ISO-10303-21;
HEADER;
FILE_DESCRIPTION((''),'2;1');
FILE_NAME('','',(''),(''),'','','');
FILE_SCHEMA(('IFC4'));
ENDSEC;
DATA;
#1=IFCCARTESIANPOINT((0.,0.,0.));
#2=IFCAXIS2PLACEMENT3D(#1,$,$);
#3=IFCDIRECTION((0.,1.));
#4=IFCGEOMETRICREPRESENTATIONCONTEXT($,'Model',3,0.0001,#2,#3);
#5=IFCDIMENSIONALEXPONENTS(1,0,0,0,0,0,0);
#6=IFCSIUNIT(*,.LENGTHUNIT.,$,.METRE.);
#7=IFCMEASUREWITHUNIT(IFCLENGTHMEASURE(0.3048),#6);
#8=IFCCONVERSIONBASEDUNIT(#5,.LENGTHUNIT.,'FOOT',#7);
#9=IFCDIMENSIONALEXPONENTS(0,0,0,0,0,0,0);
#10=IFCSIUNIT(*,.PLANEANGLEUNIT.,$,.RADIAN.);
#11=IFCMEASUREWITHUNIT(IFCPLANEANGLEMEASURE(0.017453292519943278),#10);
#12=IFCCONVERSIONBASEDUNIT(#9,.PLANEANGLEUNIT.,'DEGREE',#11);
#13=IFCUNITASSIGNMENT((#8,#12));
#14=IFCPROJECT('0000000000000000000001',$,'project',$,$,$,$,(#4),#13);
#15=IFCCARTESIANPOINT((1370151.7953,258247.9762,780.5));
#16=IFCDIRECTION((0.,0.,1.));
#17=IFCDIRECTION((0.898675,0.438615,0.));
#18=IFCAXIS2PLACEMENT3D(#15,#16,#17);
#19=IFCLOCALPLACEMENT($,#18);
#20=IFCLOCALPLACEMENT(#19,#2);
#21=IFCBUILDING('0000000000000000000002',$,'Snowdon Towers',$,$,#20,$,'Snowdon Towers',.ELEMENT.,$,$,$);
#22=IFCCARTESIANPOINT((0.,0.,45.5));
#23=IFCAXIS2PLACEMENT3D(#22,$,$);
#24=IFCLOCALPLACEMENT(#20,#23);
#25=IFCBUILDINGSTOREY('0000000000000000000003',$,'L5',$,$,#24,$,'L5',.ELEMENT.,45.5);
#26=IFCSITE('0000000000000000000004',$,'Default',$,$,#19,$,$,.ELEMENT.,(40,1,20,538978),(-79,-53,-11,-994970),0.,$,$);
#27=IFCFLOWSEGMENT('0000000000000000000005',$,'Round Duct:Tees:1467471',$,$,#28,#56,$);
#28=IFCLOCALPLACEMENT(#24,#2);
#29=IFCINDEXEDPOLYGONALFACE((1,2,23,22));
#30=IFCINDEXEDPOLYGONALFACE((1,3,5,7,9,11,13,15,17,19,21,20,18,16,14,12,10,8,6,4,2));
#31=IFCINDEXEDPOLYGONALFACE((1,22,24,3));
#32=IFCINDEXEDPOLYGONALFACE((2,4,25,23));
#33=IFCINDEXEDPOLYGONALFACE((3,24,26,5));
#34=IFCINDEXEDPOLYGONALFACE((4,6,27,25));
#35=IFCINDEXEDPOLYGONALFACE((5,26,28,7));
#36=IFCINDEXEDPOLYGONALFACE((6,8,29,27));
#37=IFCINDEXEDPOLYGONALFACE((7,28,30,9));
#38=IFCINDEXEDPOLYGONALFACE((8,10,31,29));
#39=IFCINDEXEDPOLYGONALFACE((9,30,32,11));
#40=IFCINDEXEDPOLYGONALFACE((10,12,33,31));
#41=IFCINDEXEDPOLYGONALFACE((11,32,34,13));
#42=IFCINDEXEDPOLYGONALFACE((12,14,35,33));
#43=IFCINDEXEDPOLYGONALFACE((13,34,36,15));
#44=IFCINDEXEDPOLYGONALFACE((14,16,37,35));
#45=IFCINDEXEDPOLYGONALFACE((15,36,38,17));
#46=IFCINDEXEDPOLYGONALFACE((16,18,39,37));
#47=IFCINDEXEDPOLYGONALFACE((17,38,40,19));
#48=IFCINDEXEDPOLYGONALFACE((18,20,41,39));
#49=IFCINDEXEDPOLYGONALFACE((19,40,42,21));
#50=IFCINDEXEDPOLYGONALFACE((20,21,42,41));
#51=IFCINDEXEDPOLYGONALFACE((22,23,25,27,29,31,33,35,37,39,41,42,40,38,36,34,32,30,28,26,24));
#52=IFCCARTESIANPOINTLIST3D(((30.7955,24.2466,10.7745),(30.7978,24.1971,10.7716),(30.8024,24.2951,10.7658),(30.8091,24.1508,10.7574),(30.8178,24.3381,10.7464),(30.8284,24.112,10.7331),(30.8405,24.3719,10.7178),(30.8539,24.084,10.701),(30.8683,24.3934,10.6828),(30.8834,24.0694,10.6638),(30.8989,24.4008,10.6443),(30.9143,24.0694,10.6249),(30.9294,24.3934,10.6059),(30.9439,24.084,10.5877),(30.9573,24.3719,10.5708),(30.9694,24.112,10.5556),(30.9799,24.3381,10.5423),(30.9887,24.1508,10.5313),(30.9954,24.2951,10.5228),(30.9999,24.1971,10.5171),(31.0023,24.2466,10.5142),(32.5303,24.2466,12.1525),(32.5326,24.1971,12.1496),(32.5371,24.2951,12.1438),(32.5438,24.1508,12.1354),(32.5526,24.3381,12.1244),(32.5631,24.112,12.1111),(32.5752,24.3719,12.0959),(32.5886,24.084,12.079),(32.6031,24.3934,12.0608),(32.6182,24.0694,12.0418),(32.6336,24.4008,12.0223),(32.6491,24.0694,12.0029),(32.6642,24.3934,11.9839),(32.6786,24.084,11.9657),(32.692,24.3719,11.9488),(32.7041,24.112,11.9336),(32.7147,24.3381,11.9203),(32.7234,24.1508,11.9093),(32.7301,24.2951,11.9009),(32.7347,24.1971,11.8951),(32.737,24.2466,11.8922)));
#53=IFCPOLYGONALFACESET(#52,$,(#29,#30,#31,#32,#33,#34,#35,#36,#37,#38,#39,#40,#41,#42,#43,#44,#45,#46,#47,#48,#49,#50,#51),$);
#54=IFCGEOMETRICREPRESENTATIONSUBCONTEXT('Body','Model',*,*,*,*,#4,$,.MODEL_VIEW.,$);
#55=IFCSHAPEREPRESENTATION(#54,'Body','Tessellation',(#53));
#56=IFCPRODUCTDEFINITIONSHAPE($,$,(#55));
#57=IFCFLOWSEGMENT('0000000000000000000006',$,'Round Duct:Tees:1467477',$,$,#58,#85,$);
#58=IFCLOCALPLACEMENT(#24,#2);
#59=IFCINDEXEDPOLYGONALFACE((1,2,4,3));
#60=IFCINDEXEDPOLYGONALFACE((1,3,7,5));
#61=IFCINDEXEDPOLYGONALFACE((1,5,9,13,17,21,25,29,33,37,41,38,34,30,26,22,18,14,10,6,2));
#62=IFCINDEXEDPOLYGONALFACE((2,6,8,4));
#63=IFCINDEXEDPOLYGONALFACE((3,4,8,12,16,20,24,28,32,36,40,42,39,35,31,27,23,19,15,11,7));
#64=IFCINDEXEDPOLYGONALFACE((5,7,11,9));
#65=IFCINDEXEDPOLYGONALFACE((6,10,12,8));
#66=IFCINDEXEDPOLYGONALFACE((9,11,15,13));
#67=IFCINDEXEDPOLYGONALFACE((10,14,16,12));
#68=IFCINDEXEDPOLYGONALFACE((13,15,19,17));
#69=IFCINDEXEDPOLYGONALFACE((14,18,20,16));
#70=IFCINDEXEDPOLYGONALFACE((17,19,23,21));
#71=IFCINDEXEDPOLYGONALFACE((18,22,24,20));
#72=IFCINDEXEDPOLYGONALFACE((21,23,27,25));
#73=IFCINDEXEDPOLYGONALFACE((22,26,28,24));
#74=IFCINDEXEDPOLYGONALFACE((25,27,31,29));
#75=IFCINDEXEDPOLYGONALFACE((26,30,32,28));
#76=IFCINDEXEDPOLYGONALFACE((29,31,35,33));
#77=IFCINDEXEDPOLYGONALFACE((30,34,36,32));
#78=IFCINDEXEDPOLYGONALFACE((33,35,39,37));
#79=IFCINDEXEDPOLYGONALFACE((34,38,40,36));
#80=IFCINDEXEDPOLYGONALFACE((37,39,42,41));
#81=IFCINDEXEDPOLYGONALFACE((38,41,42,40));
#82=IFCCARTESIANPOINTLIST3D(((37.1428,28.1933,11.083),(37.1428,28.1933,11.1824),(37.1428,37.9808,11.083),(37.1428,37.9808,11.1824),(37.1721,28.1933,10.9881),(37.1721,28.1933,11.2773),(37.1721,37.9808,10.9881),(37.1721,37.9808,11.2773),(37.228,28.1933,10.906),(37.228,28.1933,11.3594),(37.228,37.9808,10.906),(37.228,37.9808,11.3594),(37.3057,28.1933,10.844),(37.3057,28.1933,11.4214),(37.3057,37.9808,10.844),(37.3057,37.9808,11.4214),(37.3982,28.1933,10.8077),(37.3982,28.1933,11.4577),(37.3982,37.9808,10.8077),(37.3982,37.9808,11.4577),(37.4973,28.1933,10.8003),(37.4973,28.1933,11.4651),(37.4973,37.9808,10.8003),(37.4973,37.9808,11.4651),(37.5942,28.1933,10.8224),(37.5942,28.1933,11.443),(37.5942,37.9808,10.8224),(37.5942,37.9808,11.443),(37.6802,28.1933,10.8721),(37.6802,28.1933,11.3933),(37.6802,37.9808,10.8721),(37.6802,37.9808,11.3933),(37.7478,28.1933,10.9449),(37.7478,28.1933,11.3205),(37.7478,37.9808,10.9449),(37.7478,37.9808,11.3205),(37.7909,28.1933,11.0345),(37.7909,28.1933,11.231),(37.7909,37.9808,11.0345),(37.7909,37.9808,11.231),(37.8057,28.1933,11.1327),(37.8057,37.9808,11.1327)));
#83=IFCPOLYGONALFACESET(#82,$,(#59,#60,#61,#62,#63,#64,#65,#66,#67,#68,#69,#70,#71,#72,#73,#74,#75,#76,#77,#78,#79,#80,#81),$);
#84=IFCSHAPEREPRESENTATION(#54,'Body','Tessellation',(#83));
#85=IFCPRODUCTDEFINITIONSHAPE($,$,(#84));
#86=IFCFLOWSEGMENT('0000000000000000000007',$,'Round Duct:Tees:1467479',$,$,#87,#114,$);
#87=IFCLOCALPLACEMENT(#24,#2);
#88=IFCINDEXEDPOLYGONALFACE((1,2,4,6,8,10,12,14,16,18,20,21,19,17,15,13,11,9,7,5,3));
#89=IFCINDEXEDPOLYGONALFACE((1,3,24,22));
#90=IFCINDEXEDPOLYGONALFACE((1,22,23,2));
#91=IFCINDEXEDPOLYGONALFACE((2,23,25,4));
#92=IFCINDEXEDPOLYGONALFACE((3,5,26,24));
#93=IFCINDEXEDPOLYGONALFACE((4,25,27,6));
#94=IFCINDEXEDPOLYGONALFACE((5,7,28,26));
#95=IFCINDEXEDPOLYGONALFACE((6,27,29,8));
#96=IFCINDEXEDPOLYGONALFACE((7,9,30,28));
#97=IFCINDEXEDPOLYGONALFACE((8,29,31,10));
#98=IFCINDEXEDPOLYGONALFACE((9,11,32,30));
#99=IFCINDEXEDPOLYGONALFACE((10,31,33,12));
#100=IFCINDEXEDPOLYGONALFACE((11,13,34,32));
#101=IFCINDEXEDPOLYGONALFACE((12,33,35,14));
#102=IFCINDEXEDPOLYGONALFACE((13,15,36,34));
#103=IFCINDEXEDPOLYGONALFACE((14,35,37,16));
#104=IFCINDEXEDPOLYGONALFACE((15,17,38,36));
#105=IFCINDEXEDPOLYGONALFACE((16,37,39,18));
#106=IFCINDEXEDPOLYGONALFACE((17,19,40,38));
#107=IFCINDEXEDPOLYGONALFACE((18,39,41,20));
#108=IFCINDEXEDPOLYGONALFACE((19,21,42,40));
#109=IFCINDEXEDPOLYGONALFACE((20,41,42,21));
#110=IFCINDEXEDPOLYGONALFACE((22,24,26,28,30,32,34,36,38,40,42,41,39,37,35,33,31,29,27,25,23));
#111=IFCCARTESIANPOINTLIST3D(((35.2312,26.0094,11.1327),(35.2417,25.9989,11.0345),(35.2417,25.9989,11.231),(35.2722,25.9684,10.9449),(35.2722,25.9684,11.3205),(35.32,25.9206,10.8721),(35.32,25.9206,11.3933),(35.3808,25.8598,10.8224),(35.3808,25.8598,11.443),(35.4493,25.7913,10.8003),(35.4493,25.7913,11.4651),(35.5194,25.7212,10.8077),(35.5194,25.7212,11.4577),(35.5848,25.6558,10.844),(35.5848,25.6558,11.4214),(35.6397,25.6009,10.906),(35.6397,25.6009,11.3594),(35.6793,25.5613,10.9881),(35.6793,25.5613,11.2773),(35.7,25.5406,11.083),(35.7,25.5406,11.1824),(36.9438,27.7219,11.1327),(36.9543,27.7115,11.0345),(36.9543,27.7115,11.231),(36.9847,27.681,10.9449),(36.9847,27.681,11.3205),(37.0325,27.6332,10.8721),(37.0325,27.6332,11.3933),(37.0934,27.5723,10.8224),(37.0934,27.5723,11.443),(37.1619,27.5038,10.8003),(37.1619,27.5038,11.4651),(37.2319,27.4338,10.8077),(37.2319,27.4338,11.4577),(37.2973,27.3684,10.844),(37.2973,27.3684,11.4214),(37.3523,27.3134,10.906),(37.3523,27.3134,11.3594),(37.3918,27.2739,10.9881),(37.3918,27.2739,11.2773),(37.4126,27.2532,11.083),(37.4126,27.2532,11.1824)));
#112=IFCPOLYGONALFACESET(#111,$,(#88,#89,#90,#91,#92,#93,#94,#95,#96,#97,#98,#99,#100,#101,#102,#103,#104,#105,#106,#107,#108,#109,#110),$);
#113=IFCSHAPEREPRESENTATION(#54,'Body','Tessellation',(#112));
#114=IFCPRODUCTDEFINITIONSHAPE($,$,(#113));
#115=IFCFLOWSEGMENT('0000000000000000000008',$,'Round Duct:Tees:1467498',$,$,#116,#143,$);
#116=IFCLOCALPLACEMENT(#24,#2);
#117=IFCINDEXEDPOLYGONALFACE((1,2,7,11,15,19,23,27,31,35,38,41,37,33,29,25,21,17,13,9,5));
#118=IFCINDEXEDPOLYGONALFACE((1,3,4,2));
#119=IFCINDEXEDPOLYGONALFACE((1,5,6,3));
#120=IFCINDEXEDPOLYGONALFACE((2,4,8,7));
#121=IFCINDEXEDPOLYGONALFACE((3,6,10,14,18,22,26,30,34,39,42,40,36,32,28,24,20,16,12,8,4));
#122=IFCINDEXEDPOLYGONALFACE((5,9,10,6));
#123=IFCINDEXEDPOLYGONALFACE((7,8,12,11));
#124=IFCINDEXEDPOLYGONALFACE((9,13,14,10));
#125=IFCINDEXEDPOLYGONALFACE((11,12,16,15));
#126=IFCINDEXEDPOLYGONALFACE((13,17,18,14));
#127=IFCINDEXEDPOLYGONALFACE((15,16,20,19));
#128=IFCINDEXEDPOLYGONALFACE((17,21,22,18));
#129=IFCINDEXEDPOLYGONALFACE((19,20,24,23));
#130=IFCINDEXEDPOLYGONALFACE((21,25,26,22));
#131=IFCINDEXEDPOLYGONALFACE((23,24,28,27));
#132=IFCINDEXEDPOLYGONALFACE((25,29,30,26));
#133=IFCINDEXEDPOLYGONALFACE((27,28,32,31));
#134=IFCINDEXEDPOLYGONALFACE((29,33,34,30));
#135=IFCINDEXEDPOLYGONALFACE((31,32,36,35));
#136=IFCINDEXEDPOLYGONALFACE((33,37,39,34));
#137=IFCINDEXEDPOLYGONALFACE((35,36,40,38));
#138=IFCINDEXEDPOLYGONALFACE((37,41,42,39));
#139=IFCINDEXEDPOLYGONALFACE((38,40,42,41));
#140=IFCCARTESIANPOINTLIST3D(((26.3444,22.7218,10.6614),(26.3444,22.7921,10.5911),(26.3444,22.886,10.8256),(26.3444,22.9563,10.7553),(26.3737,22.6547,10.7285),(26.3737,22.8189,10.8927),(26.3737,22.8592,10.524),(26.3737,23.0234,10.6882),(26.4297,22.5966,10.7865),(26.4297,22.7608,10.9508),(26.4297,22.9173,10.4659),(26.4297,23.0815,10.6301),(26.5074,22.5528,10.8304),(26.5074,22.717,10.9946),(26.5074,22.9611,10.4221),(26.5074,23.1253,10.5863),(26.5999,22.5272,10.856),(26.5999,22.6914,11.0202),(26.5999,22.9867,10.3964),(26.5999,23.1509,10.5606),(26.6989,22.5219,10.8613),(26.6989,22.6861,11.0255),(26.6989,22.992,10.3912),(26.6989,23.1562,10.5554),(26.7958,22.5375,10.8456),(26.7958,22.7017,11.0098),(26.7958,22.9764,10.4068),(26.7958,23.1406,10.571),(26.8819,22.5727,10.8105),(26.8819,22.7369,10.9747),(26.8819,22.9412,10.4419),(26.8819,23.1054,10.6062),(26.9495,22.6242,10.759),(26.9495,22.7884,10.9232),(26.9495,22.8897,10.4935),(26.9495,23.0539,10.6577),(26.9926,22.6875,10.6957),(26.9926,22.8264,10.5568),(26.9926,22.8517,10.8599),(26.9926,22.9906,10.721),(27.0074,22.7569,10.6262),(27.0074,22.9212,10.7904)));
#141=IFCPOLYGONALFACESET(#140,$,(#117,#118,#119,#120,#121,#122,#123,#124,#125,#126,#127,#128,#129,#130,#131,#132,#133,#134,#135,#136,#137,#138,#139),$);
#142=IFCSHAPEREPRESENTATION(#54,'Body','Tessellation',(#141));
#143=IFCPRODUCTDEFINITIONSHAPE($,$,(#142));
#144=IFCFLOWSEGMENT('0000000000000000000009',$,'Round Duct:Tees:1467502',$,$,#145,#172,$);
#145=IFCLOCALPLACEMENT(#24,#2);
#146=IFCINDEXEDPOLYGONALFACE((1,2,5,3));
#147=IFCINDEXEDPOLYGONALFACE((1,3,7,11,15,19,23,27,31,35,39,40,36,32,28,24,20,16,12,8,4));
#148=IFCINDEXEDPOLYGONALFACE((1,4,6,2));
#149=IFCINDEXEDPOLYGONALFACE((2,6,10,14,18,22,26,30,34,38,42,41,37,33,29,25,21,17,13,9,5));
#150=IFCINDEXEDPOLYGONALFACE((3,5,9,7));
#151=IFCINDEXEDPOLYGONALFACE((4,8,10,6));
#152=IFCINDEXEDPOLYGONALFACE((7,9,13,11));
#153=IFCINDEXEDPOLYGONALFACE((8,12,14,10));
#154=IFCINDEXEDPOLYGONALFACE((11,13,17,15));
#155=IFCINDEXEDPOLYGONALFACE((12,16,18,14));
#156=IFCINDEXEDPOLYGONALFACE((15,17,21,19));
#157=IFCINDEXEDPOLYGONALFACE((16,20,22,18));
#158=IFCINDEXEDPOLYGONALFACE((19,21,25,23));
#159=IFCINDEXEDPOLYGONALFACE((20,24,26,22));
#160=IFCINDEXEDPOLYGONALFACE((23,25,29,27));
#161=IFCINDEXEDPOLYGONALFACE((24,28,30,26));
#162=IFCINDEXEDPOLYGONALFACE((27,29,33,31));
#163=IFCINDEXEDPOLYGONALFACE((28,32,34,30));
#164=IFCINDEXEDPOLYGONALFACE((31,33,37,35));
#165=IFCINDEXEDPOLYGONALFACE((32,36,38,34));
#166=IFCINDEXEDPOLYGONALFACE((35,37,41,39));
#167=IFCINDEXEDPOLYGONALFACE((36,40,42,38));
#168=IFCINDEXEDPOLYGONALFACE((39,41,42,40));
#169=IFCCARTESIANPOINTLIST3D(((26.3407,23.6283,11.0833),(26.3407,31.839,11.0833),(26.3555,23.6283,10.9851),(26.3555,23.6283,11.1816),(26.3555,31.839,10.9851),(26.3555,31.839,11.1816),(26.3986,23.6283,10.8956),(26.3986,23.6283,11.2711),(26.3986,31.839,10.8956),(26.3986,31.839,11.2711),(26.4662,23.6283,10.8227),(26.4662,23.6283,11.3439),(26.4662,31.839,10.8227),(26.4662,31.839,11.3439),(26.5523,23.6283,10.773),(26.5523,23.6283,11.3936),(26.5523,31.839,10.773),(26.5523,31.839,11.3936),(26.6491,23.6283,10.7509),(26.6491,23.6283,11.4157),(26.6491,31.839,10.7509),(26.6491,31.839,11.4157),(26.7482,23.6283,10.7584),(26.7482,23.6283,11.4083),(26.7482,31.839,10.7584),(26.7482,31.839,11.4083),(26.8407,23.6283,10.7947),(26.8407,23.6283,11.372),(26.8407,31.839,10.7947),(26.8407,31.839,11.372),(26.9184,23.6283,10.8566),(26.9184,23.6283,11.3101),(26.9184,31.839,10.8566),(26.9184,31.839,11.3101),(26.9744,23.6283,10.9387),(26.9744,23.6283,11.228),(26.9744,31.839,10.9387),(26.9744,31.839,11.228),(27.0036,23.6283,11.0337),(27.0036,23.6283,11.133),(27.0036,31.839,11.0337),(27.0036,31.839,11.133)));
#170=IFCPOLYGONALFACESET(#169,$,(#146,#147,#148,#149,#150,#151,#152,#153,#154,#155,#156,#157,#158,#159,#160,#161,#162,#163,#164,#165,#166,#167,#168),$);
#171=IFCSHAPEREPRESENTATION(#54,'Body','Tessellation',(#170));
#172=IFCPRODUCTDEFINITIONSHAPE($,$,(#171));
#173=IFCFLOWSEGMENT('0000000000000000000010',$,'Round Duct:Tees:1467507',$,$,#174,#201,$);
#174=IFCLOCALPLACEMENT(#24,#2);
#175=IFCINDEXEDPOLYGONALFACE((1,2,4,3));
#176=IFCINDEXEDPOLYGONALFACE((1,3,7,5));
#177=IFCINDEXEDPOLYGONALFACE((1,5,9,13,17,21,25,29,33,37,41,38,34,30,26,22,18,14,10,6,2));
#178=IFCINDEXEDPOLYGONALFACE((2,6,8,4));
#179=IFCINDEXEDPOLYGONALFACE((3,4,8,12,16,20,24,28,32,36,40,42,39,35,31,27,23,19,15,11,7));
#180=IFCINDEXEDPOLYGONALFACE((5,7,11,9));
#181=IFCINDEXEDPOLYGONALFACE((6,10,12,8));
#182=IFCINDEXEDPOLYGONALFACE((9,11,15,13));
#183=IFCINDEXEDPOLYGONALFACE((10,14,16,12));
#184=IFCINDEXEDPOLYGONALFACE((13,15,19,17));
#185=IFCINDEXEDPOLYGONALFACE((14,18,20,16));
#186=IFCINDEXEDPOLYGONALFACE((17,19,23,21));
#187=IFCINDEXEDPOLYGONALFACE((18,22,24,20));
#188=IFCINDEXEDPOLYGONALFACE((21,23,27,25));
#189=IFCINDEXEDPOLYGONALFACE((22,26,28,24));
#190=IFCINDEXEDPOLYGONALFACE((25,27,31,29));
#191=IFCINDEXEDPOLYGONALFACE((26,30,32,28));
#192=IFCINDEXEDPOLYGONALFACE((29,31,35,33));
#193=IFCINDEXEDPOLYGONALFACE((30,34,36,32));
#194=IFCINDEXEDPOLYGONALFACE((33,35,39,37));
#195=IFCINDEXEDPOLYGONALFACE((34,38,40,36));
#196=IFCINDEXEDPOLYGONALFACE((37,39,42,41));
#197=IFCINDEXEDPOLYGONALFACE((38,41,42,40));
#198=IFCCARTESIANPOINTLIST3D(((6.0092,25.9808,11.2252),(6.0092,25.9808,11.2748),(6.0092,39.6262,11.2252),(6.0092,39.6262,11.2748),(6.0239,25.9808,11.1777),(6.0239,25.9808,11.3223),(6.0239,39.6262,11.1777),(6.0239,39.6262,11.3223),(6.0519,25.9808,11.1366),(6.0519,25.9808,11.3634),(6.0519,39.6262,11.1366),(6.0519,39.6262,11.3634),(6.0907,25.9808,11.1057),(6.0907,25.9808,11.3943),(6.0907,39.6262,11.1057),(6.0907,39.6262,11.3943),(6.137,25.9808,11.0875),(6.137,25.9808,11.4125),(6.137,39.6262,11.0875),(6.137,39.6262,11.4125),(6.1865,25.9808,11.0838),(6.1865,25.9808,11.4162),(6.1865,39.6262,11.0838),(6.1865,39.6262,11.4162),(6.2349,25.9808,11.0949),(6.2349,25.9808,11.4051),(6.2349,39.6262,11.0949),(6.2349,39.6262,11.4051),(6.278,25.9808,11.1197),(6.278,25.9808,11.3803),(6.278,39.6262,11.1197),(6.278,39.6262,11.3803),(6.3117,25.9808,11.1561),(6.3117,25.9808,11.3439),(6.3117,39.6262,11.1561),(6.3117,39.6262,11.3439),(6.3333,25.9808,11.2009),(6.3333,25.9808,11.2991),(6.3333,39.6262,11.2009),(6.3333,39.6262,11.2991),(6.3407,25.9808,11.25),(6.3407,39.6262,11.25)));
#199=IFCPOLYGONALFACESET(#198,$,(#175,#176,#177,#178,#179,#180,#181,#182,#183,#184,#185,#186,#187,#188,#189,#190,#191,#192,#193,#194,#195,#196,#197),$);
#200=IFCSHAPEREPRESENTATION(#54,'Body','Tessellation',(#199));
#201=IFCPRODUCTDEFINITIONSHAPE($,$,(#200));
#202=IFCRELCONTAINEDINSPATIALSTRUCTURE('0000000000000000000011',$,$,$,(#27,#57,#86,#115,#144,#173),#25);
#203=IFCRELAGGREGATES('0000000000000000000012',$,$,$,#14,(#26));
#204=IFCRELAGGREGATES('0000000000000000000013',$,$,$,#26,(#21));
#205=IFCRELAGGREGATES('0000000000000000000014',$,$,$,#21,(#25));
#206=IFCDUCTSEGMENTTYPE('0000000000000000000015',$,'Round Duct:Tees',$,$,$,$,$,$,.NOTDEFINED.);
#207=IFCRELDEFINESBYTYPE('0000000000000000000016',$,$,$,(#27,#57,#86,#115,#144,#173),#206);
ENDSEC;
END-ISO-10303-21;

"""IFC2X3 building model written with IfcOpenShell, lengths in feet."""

from ifc_helpers import new_model, entity, si_unit, converted_unit, direction, frame, frame_2d, origin, origin_2d_with_axis, place, context, subcontext, project, spatial, circle, extrude, type_object, element, save


model = new_model("IFC2X3")

# Units and contexts
model_context = context("Model", 3, precision=0.0001, world=origin(), true_north=direction((0.0, 1.0)))
body_context = subcontext(model_context, "Body", "Model", "MODEL_VIEW")
ifc_project = project(units=[converted_unit("LENGTHUNIT", "FOOT", entity("IfcLengthMeasure", 0.3048), si_unit("LENGTHUNIT", "METRE"), dimensions=[1, 0, 0, 0, 0, 0, 0]), converted_unit("PLANEANGLEUNIT", "DEGREE", entity("IfcPlaneAngleMeasure", 0.017453292519943278), si_unit("PLANEANGLEUNIT", "RADIAN"), dimensions=[0, 0, 0, 0, 0, 0, 0])], contexts=[model_context])

# Site, building, storey
site_placement = place(None, frame((1370151.7953, 258247.9762, 780.5), z_axis=(0.0, 0.0, 1.0), x_axis=(0.898675, 0.438615, 0.0)))
site = spatial("IfcSite", under=ifc_project, at=site_placement, Name="Default", CompositionType="ELEMENT", RefLatitude=(40, 1, 20, 538978), RefLongitude=(-79, -53, -11, -994970), RefElevation=0.0)
building_placement = place(site_placement, origin())
building = spatial("IfcBuilding", under=site, at=building_placement, Name="Snowdon Towers", LongName="Snowdon Towers", CompositionType="ELEMENT")
storey_placement = place(building_placement, frame((0.0, 0.0, 45.5)))
storey = spatial("IfcBuildingStorey", under=building, at=storey_placement, Name="L5", LongName="L5", CompositionType="ELEMENT", Elevation=45.5)

# Flow segments
duct_segment_type = type_object("IfcDuctSegmentType", Name="Round Duct:Tees", PredefinedType="NOTDEFINED")
flow_segment_1_placement = place(storey_placement, origin())
element("IfcFlowSegment", 1, at=flow_segment_1_placement, inside=storey, type_object=duct_segment_type, Name="Round Duct:Tees:1467471", context=body_context, shape_type="SweptSolid", body=[
    extrude(circle(Radius=0.1667, at=frame_2d((0.0, 0.0), x_axis=(1.0, 0.0))), frame((30.8989, 24.2342, 10.6443), z_axis=(0.78302, 0.0, 0.621996), x_axis=(0.0, 1.0, 0.0)), (0.0, 0.0, 1.0), 2.2155),
])
flow_segment_2_placement = place(storey_placement, origin())
element("IfcFlowSegment", 2, at=flow_segment_2_placement, inside=storey, type_object=duct_segment_type, Name="Round Duct:Tees:1467477", context=body_context, shape_type="SweptSolid", body=[
    extrude(circle(Radius=0.3333, at=frame_2d((0.0, 0.0), x_axis=(1.0, 0.0))), frame((37.4724, 28.1933, 11.1327), z_axis=(0.0, 1.0, 0.0), x_axis=(1.0, 0.0, 0.0)), (0.0, 0.0, 1.0), 9.7874),
])
flow_segment_3_placement = place(storey_placement, origin())
element("IfcFlowSegment", 3, at=flow_segment_3_placement, inside=storey, type_object=duct_segment_type, Name="Round Duct:Tees:1467479", context=body_context, shape_type="SweptSolid", body=[
    extrude(circle(Radius=0.3333, at=origin_2d_with_axis()), frame((35.4669, 25.7737, 11.1327), z_axis=(0.707107, 0.707107, 0.0), x_axis=(-0.707107, 0.707107, 0.0)), (0.0, 0.0, 1.0), 2.4219),
])
flow_segment_4_placement = place(storey_placement, origin())
element("IfcFlowSegment", 4, at=flow_segment_4_placement, inside=storey, type_object=duct_segment_type, Name="Round Duct:Tees:1467498", context=body_context, shape_type="SweptSolid", body=[
    extrude(circle(Radius=0.3333, at=frame_2d((0.0, 0.0), x_axis=(1.0, 0.0))), frame((26.674, 22.7569, 10.6262), z_axis=(0.0, 0.707107, 0.707107), x_axis=(1.0, 0.0, 0.0)), (0.0, 0.0, 1.0), 0.2322),
])
flow_segment_5_placement = place(storey_placement, origin())
element("IfcFlowSegment", 5, at=flow_segment_5_placement, inside=storey, type_object=duct_segment_type, Name="Round Duct:Tees:1467502", context=body_context, shape_type="SweptSolid", body=[
    extrude(circle(Radius=0.3333, at=frame_2d((0.0, 0.0), x_axis=(1.0, 0.0))), frame((26.674, 23.6283, 11.0833), z_axis=(0.0, 1.0, 0.0), x_axis=(-1.0, 0.0, 0.0)), (0.0, 0.0, 1.0), 8.2108),
])
flow_segment_6_placement = place(storey_placement, origin())
element("IfcFlowSegment", 6, at=flow_segment_6_placement, inside=storey, type_object=duct_segment_type, Name="Round Duct:Tees:1467507", context=body_context, shape_type="SweptSolid", body=[
    extrude(circle(Radius=0.1667, at=frame_2d((0.0, 0.0), x_axis=(1.0, 0.0))), frame((6.174, 25.9808, 11.25), z_axis=(0.0, 1.0, 0.0), x_axis=(1.0, 0.0, 0.0)), (0.0, 0.0, 1.0), 13.6454),
])

save(model, "model.ifc")
